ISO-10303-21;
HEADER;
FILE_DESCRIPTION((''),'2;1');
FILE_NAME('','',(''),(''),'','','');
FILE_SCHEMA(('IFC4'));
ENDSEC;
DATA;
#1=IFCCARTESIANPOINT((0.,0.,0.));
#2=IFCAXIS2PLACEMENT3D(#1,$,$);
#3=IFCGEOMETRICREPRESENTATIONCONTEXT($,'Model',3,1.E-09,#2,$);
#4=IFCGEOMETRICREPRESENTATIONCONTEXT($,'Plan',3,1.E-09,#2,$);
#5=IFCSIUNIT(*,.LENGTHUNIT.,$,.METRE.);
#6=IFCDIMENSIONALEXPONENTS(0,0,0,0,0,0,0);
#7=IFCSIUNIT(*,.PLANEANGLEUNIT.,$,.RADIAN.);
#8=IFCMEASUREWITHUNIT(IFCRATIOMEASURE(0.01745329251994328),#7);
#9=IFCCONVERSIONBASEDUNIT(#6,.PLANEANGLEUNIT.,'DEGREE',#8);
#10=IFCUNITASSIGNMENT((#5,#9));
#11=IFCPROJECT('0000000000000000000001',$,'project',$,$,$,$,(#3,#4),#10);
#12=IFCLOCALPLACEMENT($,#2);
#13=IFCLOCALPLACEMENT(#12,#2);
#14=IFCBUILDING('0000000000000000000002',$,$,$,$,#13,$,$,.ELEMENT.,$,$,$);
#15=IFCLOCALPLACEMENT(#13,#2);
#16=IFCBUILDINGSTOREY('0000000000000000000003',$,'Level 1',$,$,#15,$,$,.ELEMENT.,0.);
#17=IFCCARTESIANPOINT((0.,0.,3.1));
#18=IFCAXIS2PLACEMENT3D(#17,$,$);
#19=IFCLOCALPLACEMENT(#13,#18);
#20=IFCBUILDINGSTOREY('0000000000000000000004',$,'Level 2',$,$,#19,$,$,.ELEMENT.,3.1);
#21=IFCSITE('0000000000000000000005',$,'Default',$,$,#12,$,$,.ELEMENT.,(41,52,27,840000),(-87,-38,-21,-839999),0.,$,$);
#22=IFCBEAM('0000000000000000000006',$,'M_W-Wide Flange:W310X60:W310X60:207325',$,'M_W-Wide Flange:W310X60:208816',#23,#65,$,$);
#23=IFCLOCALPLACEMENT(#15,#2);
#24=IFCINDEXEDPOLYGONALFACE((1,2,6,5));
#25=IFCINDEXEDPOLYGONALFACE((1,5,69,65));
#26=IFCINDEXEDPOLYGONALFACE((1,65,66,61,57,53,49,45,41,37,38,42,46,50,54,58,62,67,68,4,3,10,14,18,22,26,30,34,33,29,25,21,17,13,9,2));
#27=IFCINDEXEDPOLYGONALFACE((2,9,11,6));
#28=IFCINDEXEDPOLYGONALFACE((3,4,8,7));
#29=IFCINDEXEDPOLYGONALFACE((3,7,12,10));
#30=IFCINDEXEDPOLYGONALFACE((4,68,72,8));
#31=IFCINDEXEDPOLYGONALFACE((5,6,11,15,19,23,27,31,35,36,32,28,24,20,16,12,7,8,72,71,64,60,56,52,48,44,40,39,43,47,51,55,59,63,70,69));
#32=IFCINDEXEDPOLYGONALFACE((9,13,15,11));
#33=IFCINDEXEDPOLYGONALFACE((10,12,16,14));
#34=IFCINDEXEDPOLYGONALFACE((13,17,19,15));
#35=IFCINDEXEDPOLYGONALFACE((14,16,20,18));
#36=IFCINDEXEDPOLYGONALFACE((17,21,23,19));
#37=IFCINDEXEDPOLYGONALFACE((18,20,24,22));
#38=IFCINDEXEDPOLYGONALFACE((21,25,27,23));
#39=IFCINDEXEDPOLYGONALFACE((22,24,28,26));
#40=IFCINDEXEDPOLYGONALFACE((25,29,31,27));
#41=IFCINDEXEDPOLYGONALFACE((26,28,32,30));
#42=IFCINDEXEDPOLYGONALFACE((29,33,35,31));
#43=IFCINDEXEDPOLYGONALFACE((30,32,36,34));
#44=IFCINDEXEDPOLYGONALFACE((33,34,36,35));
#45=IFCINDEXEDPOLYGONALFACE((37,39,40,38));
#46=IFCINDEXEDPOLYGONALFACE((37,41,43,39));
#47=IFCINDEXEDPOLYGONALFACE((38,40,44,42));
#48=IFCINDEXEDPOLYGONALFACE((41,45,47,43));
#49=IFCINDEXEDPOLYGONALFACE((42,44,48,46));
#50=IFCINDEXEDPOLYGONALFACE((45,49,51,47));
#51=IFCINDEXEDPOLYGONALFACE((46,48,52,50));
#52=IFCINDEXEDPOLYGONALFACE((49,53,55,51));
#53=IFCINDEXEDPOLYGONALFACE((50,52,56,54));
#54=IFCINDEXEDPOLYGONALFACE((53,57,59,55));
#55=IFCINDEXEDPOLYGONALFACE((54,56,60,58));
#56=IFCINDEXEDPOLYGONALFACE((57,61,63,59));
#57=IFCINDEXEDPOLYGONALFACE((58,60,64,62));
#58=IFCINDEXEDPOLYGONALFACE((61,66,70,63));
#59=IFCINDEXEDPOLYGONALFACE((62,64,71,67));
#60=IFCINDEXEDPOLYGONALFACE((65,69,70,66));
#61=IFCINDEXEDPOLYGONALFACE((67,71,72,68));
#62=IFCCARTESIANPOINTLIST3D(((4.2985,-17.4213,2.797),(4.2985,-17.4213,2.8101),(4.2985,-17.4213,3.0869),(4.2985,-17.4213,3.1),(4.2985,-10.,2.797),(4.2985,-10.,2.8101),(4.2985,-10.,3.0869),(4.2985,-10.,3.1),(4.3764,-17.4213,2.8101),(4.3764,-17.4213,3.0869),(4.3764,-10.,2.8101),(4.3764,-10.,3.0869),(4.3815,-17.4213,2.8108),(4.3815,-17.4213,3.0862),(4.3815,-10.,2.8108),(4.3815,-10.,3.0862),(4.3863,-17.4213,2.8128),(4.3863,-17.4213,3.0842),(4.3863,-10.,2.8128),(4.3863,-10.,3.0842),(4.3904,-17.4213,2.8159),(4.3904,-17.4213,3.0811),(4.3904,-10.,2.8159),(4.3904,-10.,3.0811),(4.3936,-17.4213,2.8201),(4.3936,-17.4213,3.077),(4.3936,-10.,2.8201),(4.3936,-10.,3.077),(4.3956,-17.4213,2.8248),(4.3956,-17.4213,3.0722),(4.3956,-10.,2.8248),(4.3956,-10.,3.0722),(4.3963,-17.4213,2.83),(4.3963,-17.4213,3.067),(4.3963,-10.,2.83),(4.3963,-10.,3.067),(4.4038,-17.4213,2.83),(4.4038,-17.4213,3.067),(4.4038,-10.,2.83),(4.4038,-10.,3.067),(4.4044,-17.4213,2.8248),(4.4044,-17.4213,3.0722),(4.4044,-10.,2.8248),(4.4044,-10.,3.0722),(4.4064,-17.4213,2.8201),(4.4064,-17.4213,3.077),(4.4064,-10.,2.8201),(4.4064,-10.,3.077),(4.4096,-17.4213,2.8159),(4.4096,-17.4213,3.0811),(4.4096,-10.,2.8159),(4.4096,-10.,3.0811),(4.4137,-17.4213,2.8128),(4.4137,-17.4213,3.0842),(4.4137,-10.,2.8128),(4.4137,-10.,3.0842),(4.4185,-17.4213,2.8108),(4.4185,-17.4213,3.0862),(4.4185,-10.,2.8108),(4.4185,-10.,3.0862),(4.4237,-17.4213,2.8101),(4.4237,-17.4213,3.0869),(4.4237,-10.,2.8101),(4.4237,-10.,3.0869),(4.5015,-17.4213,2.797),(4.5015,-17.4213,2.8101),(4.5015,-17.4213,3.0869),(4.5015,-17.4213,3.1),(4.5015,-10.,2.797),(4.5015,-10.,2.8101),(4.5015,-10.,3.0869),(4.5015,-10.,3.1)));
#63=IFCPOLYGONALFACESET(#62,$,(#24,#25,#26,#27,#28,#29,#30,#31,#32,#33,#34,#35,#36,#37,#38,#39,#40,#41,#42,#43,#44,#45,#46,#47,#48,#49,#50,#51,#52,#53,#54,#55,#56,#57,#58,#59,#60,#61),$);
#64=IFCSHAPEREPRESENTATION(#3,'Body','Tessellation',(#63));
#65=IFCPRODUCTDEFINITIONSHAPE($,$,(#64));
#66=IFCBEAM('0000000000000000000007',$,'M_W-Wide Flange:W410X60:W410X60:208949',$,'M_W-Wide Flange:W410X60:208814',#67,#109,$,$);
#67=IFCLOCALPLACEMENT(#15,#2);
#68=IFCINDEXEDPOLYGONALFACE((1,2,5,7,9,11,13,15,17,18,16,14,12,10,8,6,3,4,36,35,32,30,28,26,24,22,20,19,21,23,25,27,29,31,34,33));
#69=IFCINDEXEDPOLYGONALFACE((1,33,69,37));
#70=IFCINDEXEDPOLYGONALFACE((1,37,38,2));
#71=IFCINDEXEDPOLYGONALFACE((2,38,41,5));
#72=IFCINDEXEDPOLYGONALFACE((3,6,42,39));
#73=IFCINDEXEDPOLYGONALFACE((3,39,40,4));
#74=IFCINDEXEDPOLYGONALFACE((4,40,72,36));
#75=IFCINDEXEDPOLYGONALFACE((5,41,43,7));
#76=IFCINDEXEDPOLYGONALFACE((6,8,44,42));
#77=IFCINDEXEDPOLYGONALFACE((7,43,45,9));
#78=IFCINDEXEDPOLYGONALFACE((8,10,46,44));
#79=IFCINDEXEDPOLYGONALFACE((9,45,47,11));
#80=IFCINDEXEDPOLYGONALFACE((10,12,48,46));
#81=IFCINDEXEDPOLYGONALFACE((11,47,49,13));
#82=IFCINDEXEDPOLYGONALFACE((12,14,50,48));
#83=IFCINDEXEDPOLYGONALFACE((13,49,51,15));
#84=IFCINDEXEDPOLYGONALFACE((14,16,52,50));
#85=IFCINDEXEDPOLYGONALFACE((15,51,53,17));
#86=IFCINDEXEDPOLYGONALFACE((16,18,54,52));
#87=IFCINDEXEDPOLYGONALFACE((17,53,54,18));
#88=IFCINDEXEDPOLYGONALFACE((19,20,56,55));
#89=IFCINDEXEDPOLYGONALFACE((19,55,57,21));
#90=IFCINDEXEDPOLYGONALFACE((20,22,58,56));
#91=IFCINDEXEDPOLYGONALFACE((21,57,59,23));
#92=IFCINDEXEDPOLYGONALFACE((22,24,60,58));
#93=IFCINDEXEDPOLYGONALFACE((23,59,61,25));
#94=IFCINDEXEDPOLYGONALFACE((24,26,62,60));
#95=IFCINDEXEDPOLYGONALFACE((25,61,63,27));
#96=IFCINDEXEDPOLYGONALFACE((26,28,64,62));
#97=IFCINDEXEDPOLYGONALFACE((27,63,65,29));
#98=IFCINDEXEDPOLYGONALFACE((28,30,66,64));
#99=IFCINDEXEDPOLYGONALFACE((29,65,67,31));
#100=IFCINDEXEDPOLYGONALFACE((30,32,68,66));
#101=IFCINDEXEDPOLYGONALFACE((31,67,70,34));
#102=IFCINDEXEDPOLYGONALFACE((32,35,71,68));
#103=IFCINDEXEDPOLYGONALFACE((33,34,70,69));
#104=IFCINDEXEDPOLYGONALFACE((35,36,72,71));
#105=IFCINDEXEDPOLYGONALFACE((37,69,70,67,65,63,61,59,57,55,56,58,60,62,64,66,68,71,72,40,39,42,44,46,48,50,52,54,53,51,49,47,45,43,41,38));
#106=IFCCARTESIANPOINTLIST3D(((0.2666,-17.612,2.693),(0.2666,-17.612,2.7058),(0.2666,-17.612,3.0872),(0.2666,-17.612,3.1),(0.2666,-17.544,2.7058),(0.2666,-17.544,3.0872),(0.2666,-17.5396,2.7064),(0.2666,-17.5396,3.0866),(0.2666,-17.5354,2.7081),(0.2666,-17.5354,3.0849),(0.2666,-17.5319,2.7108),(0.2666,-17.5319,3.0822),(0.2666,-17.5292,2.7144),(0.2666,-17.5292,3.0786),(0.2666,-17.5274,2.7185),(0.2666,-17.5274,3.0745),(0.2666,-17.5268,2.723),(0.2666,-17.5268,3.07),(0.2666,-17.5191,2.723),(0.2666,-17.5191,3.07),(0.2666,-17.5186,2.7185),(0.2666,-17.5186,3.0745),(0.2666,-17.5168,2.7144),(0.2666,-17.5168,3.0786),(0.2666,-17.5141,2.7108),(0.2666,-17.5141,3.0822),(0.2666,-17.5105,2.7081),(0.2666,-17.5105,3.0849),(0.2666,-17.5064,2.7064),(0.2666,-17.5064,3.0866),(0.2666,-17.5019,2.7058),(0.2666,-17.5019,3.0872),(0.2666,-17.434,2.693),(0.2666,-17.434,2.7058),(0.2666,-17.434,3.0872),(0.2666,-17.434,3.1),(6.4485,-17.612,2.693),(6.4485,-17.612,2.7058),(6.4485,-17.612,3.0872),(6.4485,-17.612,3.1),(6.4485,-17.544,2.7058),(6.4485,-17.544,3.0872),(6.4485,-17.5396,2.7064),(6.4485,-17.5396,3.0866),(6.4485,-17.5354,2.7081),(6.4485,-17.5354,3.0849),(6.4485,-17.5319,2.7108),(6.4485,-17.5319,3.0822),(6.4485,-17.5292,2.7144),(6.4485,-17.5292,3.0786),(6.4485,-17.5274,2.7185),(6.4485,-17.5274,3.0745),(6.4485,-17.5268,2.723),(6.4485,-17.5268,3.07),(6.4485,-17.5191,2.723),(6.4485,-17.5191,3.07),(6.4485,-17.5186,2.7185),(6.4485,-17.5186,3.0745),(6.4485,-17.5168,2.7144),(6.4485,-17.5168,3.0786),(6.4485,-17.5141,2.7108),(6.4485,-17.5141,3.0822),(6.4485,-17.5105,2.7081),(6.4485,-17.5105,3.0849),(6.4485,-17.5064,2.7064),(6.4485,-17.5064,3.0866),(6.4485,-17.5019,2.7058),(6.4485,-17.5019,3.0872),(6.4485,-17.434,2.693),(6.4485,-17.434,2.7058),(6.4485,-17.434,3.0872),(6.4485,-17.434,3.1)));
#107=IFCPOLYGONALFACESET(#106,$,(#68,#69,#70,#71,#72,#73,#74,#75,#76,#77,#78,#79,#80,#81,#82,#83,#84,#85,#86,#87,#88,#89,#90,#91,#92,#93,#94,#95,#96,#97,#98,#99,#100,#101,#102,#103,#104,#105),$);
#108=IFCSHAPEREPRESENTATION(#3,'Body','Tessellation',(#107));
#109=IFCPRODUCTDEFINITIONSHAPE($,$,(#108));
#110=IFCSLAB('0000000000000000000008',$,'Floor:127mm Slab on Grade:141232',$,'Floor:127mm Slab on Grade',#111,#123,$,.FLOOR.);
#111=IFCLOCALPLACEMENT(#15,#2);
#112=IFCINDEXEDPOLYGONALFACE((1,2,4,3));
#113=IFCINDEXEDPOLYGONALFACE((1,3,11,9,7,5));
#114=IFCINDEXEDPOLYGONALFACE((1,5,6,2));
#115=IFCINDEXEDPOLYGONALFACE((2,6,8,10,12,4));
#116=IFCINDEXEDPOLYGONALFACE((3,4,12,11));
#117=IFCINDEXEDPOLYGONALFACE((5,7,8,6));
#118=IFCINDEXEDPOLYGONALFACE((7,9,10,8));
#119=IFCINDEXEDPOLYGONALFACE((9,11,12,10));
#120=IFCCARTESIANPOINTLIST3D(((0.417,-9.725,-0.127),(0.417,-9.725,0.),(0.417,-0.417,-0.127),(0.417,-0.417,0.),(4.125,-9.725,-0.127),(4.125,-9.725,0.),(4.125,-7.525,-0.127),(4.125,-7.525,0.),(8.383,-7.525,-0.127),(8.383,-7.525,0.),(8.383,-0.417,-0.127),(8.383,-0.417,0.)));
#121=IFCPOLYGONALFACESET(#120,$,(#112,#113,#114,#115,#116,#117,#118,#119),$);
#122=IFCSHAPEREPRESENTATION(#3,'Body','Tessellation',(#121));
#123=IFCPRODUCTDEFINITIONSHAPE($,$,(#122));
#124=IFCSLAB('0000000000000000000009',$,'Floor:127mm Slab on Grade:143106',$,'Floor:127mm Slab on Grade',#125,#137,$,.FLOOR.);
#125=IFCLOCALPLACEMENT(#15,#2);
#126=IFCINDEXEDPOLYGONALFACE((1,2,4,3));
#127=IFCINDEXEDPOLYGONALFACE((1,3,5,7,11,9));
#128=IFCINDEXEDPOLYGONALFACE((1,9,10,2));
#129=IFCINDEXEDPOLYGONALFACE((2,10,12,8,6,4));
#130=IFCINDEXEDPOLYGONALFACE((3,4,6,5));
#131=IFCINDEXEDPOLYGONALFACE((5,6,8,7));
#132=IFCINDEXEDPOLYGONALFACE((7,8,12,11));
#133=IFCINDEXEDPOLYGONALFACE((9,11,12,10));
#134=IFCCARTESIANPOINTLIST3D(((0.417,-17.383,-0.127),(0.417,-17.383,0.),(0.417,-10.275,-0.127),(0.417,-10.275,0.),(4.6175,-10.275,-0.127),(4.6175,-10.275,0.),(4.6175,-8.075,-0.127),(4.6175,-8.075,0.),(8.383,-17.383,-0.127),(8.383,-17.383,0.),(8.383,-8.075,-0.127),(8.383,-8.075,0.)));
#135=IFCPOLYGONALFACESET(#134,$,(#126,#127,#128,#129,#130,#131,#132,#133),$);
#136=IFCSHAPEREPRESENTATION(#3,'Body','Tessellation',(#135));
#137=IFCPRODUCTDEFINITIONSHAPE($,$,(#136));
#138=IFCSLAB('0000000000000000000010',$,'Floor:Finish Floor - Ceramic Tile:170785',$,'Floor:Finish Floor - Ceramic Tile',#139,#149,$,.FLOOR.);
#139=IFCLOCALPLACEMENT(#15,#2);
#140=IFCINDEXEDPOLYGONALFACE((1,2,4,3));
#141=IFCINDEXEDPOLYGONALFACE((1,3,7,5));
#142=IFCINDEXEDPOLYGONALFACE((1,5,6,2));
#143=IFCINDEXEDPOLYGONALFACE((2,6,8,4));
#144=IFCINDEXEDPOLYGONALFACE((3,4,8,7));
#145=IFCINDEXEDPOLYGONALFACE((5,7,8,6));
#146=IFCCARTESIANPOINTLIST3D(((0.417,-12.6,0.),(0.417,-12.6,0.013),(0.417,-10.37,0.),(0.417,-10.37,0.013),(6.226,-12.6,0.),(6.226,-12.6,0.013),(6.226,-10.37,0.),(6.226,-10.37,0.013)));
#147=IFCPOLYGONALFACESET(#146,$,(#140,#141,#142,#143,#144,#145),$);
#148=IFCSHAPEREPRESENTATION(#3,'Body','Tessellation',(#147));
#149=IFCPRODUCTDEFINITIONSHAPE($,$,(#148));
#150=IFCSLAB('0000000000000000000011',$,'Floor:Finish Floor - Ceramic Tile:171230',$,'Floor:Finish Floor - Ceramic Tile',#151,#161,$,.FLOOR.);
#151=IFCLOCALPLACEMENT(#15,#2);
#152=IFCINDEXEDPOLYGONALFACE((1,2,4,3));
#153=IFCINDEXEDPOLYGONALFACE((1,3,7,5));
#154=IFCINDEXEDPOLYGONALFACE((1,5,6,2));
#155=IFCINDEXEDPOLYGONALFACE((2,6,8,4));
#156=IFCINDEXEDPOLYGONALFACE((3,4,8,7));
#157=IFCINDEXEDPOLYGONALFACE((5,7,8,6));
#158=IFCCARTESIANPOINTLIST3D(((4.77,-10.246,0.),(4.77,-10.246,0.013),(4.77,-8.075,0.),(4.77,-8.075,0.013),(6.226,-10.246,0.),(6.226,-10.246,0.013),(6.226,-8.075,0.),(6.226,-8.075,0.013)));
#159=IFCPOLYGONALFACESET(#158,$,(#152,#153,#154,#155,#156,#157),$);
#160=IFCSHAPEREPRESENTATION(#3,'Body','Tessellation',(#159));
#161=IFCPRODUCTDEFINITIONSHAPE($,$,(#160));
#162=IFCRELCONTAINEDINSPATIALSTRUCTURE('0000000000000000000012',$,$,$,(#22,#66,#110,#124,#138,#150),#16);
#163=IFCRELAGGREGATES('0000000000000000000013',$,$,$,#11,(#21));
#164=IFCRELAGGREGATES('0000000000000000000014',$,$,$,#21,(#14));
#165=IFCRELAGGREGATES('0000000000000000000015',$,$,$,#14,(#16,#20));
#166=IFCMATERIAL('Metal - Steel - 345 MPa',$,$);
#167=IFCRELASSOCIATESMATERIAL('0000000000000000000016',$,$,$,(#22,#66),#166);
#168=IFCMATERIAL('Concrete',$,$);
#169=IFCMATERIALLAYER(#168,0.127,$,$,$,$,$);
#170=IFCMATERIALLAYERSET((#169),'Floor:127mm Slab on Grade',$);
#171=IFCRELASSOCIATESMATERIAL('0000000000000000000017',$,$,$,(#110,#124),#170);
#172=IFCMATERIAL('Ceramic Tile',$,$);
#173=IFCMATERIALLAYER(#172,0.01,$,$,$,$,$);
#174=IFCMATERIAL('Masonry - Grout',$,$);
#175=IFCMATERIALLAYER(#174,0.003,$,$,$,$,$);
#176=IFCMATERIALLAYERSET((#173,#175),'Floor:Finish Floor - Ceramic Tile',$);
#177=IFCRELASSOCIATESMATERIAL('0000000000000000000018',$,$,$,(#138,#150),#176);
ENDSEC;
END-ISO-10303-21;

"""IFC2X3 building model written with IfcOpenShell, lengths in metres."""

from ifc_helpers import new_model, entity, si_unit, converted_unit, frame, frame_2d, origin, place, context, project, spatial, polyline, circle_curve, parameter, trimmed, segment, composite_curve, rectangle, outline, extrude, material, layer, layer_set, layer_usage, element, save


model = new_model("IFC2X3")

# Units and contexts
model_context = context("Model", 3, precision=1e-09, world=origin())
plan_context = context("Plan", 3, precision=1e-09, world=origin())
ifc_project = project(units=[si_unit("LENGTHUNIT", "METRE"), converted_unit("PLANEANGLEUNIT", "DEGREE", entity("IfcRatioMeasure", 0.01745329251994328), si_unit("PLANEANGLEUNIT", "RADIAN"), dimensions=[0, 0, 0, 0, 0, 0, 0])], contexts=[model_context, plan_context])

# Site, building, storey
site_placement = place(None, origin())
site = spatial("IfcSite", under=ifc_project, at=site_placement, Name="Default", CompositionType="ELEMENT", RefLatitude=(41, 52, 27, 840000), RefLongitude=(-87, -38, -21, -839999), RefElevation=0.0)
building_placement = place(site_placement, origin())
building = spatial("IfcBuilding", under=site, at=building_placement, CompositionType="ELEMENT")
storey_1_placement = place(building_placement, origin())
storey_1 = spatial("IfcBuildingStorey", under=building, at=storey_1_placement, Name="Level 1", CompositionType="ELEMENT", Elevation=0.0)

# Beams
ifc_material_1 = material(Name="Metal - Steel - 345 MPa")
beam_1_placement = place(storey_1_placement, frame((4.4, -10.0, 3.1), z_axis=(0.0, 0.0, 1.0), x_axis=(-1.0, 0.0, 0.0)))
element("IfcBeam", 1, at=beam_1_placement, inside=storey_1, material=ifc_material_1, Name="M_W-Wide Flange:W310X60:W310X60:207325", ObjectType="M_W-Wide Flange:W310X60:208816", context=model_context, shape_type="SweptSolid", body=[
    extrude(outline(composite_curve([segment(polyline([(0.1384, -0.1015), (0.1515, -0.1015)]), True, "CONTINUOUS"), segment(polyline([(0.1515, -0.1015), (0.1515, 0.1015)]), True, "CONTINUOUS"), segment(polyline([(0.1515, 0.1015), (0.1384, 0.1015)]), True, "CONTINUOUS"), segment(polyline([(0.1384, 0.1015), (0.1384, 0.0236)]), True, "CONTINUOUS"), segment(trimmed(circle_curve(frame_2d((0.1185, 0.0236), x_axis=(0.0, 1.0)), 0.0199), [parameter(180.0)], [parameter(270.0)], True, "PARAMETER"), False, "CONTINUOUS"), segment(polyline([(0.1185, 0.0037), (-0.1185, 0.0037)]), True, "CONTINUOUS"), segment(trimmed(circle_curve(frame_2d((-0.1185, 0.0236), x_axis=(0.0, 1.0)), 0.0199), [parameter(90.0)], [parameter(180.0)], True, "PARAMETER"), False, "CONTINUOUS"), segment(polyline([(-0.1384, 0.0236), (-0.1384, 0.1015)]), True, "CONTINUOUS"), segment(polyline([(-0.1384, 0.1015), (-0.1515, 0.1015)]), True, "CONTINUOUS"), segment(polyline([(-0.1515, 0.1015), (-0.1515, -0.1015)]), True, "CONTINUOUS"), segment(polyline([(-0.1515, -0.1015), (-0.1384, -0.1015)]), True, "CONTINUOUS"), segment(polyline([(-0.1384, -0.1015), (-0.1384, -0.0237)]), True, "CONTINUOUS"), segment(trimmed(circle_curve(frame_2d((-0.1185, -0.0237), x_axis=(0.0, 1.0)), 0.0199), [parameter(360.0)], [parameter(90.0)], True, "PARAMETER"), False, "CONTINUOUS"), segment(polyline([(-0.1185, -0.0038), (0.1185, -0.0038)]), True, "CONTINUOUS"), segment(trimmed(circle_curve(frame_2d((0.1185, -0.0237), x_axis=(0.0, 1.0)), 0.0199), [parameter(270.0)], [parameter(0.0)], True, "PARAMETER"), False, "CONTINUOUS"), segment(polyline([(0.1384, -0.0237), (0.1384, -0.1015)]), True, "CONTINUOUS")], self_intersect=False)), frame((0.0, 7.4213, -0.1515), z_axis=(0.0, -1.0, 0.0), x_axis=(0.0, 0.0, -1.0)), (0.0, 0.0, 1.0), 7.4213),
])
beam_2_placement = place(storey_1_placement, frame((0.2085, -17.523, 3.1), z_axis=(0.0, 0.0, 1.0), x_axis=(0.0, -1.0, 0.0)))
element("IfcBeam", 2, at=beam_2_placement, inside=storey_1, material=ifc_material_1, Name="M_W-Wide Flange:W410X60:W410X60:208949", ObjectType="M_W-Wide Flange:W410X60:208814", context=model_context, shape_type="SweptSolid", body=[
    extrude(outline(composite_curve([segment(polyline([(-0.089, -0.1907), (-0.089, -0.2035)]), True, "CONTINUOUS"), segment(polyline([(-0.089, -0.2035), (0.089, -0.2035)]), True, "CONTINUOUS"), segment(polyline([(0.089, -0.2035), (0.089, -0.1907)]), True, "CONTINUOUS"), segment(polyline([(0.089, -0.1907), (0.021, -0.1907)]), True, "CONTINUOUS"), segment(trimmed(circle_curve(frame_2d((0.021, -0.1735), x_axis=(0.0, -1.0)), 0.0172), [parameter(270.0)], [parameter(360.0)], True, "PARAMETER"), False, "CONTINUOUS"), segment(polyline([(0.0038, -0.1735), (0.0038, 0.1735)]), True, "CONTINUOUS"), segment(trimmed(circle_curve(frame_2d((0.021, 0.1735), x_axis=(-1.0, 0.0)), 0.0172), [parameter(270.0)], [parameter(360.0)], True, "PARAMETER"), False, "CONTINUOUS"), segment(polyline([(0.021, 0.1907), (0.089, 0.1907)]), True, "CONTINUOUS"), segment(polyline([(0.089, 0.1907), (0.089, 0.2035)]), True, "CONTINUOUS"), segment(polyline([(0.089, 0.2035), (-0.089, 0.2035)]), True, "CONTINUOUS"), segment(polyline([(-0.089, 0.2035), (-0.089, 0.1907)]), True, "CONTINUOUS"), segment(polyline([(-0.089, 0.1907), (-0.0211, 0.1907)]), True, "CONTINUOUS"), segment(trimmed(circle_curve(frame_2d((-0.0211, 0.1735), x_axis=(0.0, 1.0)), 0.0172), [parameter(270.0)], [parameter(0.0)], True, "PARAMETER"), False, "CONTINUOUS"), segment(polyline([(-0.0039, 0.1735), (-0.0039, -0.1735)]), True, "CONTINUOUS"), segment(trimmed(circle_curve(frame_2d((-0.0211, -0.1735), x_axis=(1.0, 0.0)), 0.0172), [parameter(270.0)], [parameter(0.0)], True, "PARAMETER"), False, "CONTINUOUS"), segment(polyline([(-0.0211, -0.1907), (-0.089, -0.1907)]), True, "CONTINUOUS")], self_intersect=False)), frame((0.0, 0.0581, -0.2035), z_axis=(0.0, -1.0, 0.0), x_axis=(1.0, 0.0, 0.0)), (0.0, 0.0, -1.0), 6.1819),
])

# Slabs
ifc_material_2 = material(Name="Concrete")
ifc_layer_1 = layer(ifc_material_2, 0.127)
ifc_layer_set_1 = layer_set([ifc_layer_1], Name="Floor:127mm Slab on Grade")
ifc_layer_usage_1 = layer_usage(ifc_layer_set_1, "AXIS3", "POSITIVE", 0.0)
slab_1_placement = place(storey_1_placement, frame((0.417, -9.725, -0.127)))
element("IfcSlab", 3, at=slab_1_placement, inside=storey_1, material=ifc_layer_usage_1, Name="Floor:127mm Slab on Grade:141232", ObjectType="Floor:127mm Slab on Grade", PredefinedType="FLOOR", context=model_context, shape_type="SweptSolid", body=[
    extrude(outline(polyline([(-3.983, 4.654), (-3.983, -2.454), (0.275, -2.454), (0.275, -4.654), (3.983, -4.654), (3.983, 4.654), (-3.983, 4.654)])), frame((3.983, 4.654, 0.127), z_axis=(0.0, 0.0, -1.0), x_axis=(-1.0, 0.0, 0.0)), (0.0, 0.0, 1.0), 0.127),
])
slab_2_placement = place(storey_1_placement, frame((0.417, -17.383, -0.127)))
element("IfcSlab", 4, at=slab_2_placement, inside=storey_1, material=ifc_layer_usage_1, Name="Floor:127mm Slab on Grade:143106", ObjectType="Floor:127mm Slab on Grade", PredefinedType="FLOOR", context=model_context, shape_type="SweptSolid", body=[
    extrude(outline(polyline([(-3.983, 4.654), (-3.983, -4.654), (3.983, -4.654), (3.983, 2.454), (-0.2175, 2.454), (-0.2175, 4.654), (-3.983, 4.654)])), frame((3.983, 4.654, 0.127), z_axis=(0.0, 0.0, -1.0), x_axis=(-1.0, 0.0, 0.0)), (0.0, 0.0, 1.0), 0.127),
])
ifc_material_3 = material(Name="Ceramic Tile")
ifc_layer_2 = layer(ifc_material_3, 0.01)
ifc_material_4 = material(Name="Masonry - Grout")
ifc_layer_3 = layer(ifc_material_4, 0.003)
ifc_layer_set_2 = layer_set([ifc_layer_2, ifc_layer_3], Name="Floor:Finish Floor - Ceramic Tile")
ifc_layer_usage_2 = layer_usage(ifc_layer_set_2, "AXIS3", "POSITIVE", 0.0)
slab_3_placement = place(storey_1_placement, frame((0.417, -12.6, 0.0)))
element("IfcSlab", 5, at=slab_3_placement, inside=storey_1, material=ifc_layer_usage_2, Name="Floor:Finish Floor - Ceramic Tile:170785", ObjectType="Floor:Finish Floor - Ceramic Tile", PredefinedType="FLOOR", context=model_context, shape_type="SweptSolid", body=[
    extrude(rectangle(XDim=5.809, YDim=2.23, at=frame_2d((0.0, 0.0), x_axis=(-1.0, 0.0))), frame((2.9045, 1.115, 0.013), z_axis=(0.0, 0.0, -1.0), x_axis=(-1.0, 0.0, 0.0)), (0.0, 0.0, 1.0), 0.013),
])
slab_4_placement = place(storey_1_placement, frame((4.77, -10.246, 0.0)))
element("IfcSlab", 6, at=slab_4_placement, inside=storey_1, material=ifc_layer_usage_2, Name="Floor:Finish Floor - Ceramic Tile:171230", ObjectType="Floor:Finish Floor - Ceramic Tile", PredefinedType="FLOOR", context=model_context, shape_type="SweptSolid", body=[
    extrude(rectangle(XDim=1.456, YDim=2.171, at=frame_2d((0.0, 0.0), x_axis=(-1.0, 0.0))), frame((0.728, 1.0855, 0.013), z_axis=(0.0, 0.0, -1.0), x_axis=(-1.0, 0.0, 0.0)), (0.0, 0.0, 1.0), 0.013),
])

# Shared definitions
storey_2_placement = place(building_placement, frame((0.0, 0.0, 3.1)))
storey_2 = spatial("IfcBuildingStorey", under=building, at=storey_2_placement, Name="Level 2", CompositionType="ELEMENT", Elevation=3.1)

save(model, "model.ifc")
